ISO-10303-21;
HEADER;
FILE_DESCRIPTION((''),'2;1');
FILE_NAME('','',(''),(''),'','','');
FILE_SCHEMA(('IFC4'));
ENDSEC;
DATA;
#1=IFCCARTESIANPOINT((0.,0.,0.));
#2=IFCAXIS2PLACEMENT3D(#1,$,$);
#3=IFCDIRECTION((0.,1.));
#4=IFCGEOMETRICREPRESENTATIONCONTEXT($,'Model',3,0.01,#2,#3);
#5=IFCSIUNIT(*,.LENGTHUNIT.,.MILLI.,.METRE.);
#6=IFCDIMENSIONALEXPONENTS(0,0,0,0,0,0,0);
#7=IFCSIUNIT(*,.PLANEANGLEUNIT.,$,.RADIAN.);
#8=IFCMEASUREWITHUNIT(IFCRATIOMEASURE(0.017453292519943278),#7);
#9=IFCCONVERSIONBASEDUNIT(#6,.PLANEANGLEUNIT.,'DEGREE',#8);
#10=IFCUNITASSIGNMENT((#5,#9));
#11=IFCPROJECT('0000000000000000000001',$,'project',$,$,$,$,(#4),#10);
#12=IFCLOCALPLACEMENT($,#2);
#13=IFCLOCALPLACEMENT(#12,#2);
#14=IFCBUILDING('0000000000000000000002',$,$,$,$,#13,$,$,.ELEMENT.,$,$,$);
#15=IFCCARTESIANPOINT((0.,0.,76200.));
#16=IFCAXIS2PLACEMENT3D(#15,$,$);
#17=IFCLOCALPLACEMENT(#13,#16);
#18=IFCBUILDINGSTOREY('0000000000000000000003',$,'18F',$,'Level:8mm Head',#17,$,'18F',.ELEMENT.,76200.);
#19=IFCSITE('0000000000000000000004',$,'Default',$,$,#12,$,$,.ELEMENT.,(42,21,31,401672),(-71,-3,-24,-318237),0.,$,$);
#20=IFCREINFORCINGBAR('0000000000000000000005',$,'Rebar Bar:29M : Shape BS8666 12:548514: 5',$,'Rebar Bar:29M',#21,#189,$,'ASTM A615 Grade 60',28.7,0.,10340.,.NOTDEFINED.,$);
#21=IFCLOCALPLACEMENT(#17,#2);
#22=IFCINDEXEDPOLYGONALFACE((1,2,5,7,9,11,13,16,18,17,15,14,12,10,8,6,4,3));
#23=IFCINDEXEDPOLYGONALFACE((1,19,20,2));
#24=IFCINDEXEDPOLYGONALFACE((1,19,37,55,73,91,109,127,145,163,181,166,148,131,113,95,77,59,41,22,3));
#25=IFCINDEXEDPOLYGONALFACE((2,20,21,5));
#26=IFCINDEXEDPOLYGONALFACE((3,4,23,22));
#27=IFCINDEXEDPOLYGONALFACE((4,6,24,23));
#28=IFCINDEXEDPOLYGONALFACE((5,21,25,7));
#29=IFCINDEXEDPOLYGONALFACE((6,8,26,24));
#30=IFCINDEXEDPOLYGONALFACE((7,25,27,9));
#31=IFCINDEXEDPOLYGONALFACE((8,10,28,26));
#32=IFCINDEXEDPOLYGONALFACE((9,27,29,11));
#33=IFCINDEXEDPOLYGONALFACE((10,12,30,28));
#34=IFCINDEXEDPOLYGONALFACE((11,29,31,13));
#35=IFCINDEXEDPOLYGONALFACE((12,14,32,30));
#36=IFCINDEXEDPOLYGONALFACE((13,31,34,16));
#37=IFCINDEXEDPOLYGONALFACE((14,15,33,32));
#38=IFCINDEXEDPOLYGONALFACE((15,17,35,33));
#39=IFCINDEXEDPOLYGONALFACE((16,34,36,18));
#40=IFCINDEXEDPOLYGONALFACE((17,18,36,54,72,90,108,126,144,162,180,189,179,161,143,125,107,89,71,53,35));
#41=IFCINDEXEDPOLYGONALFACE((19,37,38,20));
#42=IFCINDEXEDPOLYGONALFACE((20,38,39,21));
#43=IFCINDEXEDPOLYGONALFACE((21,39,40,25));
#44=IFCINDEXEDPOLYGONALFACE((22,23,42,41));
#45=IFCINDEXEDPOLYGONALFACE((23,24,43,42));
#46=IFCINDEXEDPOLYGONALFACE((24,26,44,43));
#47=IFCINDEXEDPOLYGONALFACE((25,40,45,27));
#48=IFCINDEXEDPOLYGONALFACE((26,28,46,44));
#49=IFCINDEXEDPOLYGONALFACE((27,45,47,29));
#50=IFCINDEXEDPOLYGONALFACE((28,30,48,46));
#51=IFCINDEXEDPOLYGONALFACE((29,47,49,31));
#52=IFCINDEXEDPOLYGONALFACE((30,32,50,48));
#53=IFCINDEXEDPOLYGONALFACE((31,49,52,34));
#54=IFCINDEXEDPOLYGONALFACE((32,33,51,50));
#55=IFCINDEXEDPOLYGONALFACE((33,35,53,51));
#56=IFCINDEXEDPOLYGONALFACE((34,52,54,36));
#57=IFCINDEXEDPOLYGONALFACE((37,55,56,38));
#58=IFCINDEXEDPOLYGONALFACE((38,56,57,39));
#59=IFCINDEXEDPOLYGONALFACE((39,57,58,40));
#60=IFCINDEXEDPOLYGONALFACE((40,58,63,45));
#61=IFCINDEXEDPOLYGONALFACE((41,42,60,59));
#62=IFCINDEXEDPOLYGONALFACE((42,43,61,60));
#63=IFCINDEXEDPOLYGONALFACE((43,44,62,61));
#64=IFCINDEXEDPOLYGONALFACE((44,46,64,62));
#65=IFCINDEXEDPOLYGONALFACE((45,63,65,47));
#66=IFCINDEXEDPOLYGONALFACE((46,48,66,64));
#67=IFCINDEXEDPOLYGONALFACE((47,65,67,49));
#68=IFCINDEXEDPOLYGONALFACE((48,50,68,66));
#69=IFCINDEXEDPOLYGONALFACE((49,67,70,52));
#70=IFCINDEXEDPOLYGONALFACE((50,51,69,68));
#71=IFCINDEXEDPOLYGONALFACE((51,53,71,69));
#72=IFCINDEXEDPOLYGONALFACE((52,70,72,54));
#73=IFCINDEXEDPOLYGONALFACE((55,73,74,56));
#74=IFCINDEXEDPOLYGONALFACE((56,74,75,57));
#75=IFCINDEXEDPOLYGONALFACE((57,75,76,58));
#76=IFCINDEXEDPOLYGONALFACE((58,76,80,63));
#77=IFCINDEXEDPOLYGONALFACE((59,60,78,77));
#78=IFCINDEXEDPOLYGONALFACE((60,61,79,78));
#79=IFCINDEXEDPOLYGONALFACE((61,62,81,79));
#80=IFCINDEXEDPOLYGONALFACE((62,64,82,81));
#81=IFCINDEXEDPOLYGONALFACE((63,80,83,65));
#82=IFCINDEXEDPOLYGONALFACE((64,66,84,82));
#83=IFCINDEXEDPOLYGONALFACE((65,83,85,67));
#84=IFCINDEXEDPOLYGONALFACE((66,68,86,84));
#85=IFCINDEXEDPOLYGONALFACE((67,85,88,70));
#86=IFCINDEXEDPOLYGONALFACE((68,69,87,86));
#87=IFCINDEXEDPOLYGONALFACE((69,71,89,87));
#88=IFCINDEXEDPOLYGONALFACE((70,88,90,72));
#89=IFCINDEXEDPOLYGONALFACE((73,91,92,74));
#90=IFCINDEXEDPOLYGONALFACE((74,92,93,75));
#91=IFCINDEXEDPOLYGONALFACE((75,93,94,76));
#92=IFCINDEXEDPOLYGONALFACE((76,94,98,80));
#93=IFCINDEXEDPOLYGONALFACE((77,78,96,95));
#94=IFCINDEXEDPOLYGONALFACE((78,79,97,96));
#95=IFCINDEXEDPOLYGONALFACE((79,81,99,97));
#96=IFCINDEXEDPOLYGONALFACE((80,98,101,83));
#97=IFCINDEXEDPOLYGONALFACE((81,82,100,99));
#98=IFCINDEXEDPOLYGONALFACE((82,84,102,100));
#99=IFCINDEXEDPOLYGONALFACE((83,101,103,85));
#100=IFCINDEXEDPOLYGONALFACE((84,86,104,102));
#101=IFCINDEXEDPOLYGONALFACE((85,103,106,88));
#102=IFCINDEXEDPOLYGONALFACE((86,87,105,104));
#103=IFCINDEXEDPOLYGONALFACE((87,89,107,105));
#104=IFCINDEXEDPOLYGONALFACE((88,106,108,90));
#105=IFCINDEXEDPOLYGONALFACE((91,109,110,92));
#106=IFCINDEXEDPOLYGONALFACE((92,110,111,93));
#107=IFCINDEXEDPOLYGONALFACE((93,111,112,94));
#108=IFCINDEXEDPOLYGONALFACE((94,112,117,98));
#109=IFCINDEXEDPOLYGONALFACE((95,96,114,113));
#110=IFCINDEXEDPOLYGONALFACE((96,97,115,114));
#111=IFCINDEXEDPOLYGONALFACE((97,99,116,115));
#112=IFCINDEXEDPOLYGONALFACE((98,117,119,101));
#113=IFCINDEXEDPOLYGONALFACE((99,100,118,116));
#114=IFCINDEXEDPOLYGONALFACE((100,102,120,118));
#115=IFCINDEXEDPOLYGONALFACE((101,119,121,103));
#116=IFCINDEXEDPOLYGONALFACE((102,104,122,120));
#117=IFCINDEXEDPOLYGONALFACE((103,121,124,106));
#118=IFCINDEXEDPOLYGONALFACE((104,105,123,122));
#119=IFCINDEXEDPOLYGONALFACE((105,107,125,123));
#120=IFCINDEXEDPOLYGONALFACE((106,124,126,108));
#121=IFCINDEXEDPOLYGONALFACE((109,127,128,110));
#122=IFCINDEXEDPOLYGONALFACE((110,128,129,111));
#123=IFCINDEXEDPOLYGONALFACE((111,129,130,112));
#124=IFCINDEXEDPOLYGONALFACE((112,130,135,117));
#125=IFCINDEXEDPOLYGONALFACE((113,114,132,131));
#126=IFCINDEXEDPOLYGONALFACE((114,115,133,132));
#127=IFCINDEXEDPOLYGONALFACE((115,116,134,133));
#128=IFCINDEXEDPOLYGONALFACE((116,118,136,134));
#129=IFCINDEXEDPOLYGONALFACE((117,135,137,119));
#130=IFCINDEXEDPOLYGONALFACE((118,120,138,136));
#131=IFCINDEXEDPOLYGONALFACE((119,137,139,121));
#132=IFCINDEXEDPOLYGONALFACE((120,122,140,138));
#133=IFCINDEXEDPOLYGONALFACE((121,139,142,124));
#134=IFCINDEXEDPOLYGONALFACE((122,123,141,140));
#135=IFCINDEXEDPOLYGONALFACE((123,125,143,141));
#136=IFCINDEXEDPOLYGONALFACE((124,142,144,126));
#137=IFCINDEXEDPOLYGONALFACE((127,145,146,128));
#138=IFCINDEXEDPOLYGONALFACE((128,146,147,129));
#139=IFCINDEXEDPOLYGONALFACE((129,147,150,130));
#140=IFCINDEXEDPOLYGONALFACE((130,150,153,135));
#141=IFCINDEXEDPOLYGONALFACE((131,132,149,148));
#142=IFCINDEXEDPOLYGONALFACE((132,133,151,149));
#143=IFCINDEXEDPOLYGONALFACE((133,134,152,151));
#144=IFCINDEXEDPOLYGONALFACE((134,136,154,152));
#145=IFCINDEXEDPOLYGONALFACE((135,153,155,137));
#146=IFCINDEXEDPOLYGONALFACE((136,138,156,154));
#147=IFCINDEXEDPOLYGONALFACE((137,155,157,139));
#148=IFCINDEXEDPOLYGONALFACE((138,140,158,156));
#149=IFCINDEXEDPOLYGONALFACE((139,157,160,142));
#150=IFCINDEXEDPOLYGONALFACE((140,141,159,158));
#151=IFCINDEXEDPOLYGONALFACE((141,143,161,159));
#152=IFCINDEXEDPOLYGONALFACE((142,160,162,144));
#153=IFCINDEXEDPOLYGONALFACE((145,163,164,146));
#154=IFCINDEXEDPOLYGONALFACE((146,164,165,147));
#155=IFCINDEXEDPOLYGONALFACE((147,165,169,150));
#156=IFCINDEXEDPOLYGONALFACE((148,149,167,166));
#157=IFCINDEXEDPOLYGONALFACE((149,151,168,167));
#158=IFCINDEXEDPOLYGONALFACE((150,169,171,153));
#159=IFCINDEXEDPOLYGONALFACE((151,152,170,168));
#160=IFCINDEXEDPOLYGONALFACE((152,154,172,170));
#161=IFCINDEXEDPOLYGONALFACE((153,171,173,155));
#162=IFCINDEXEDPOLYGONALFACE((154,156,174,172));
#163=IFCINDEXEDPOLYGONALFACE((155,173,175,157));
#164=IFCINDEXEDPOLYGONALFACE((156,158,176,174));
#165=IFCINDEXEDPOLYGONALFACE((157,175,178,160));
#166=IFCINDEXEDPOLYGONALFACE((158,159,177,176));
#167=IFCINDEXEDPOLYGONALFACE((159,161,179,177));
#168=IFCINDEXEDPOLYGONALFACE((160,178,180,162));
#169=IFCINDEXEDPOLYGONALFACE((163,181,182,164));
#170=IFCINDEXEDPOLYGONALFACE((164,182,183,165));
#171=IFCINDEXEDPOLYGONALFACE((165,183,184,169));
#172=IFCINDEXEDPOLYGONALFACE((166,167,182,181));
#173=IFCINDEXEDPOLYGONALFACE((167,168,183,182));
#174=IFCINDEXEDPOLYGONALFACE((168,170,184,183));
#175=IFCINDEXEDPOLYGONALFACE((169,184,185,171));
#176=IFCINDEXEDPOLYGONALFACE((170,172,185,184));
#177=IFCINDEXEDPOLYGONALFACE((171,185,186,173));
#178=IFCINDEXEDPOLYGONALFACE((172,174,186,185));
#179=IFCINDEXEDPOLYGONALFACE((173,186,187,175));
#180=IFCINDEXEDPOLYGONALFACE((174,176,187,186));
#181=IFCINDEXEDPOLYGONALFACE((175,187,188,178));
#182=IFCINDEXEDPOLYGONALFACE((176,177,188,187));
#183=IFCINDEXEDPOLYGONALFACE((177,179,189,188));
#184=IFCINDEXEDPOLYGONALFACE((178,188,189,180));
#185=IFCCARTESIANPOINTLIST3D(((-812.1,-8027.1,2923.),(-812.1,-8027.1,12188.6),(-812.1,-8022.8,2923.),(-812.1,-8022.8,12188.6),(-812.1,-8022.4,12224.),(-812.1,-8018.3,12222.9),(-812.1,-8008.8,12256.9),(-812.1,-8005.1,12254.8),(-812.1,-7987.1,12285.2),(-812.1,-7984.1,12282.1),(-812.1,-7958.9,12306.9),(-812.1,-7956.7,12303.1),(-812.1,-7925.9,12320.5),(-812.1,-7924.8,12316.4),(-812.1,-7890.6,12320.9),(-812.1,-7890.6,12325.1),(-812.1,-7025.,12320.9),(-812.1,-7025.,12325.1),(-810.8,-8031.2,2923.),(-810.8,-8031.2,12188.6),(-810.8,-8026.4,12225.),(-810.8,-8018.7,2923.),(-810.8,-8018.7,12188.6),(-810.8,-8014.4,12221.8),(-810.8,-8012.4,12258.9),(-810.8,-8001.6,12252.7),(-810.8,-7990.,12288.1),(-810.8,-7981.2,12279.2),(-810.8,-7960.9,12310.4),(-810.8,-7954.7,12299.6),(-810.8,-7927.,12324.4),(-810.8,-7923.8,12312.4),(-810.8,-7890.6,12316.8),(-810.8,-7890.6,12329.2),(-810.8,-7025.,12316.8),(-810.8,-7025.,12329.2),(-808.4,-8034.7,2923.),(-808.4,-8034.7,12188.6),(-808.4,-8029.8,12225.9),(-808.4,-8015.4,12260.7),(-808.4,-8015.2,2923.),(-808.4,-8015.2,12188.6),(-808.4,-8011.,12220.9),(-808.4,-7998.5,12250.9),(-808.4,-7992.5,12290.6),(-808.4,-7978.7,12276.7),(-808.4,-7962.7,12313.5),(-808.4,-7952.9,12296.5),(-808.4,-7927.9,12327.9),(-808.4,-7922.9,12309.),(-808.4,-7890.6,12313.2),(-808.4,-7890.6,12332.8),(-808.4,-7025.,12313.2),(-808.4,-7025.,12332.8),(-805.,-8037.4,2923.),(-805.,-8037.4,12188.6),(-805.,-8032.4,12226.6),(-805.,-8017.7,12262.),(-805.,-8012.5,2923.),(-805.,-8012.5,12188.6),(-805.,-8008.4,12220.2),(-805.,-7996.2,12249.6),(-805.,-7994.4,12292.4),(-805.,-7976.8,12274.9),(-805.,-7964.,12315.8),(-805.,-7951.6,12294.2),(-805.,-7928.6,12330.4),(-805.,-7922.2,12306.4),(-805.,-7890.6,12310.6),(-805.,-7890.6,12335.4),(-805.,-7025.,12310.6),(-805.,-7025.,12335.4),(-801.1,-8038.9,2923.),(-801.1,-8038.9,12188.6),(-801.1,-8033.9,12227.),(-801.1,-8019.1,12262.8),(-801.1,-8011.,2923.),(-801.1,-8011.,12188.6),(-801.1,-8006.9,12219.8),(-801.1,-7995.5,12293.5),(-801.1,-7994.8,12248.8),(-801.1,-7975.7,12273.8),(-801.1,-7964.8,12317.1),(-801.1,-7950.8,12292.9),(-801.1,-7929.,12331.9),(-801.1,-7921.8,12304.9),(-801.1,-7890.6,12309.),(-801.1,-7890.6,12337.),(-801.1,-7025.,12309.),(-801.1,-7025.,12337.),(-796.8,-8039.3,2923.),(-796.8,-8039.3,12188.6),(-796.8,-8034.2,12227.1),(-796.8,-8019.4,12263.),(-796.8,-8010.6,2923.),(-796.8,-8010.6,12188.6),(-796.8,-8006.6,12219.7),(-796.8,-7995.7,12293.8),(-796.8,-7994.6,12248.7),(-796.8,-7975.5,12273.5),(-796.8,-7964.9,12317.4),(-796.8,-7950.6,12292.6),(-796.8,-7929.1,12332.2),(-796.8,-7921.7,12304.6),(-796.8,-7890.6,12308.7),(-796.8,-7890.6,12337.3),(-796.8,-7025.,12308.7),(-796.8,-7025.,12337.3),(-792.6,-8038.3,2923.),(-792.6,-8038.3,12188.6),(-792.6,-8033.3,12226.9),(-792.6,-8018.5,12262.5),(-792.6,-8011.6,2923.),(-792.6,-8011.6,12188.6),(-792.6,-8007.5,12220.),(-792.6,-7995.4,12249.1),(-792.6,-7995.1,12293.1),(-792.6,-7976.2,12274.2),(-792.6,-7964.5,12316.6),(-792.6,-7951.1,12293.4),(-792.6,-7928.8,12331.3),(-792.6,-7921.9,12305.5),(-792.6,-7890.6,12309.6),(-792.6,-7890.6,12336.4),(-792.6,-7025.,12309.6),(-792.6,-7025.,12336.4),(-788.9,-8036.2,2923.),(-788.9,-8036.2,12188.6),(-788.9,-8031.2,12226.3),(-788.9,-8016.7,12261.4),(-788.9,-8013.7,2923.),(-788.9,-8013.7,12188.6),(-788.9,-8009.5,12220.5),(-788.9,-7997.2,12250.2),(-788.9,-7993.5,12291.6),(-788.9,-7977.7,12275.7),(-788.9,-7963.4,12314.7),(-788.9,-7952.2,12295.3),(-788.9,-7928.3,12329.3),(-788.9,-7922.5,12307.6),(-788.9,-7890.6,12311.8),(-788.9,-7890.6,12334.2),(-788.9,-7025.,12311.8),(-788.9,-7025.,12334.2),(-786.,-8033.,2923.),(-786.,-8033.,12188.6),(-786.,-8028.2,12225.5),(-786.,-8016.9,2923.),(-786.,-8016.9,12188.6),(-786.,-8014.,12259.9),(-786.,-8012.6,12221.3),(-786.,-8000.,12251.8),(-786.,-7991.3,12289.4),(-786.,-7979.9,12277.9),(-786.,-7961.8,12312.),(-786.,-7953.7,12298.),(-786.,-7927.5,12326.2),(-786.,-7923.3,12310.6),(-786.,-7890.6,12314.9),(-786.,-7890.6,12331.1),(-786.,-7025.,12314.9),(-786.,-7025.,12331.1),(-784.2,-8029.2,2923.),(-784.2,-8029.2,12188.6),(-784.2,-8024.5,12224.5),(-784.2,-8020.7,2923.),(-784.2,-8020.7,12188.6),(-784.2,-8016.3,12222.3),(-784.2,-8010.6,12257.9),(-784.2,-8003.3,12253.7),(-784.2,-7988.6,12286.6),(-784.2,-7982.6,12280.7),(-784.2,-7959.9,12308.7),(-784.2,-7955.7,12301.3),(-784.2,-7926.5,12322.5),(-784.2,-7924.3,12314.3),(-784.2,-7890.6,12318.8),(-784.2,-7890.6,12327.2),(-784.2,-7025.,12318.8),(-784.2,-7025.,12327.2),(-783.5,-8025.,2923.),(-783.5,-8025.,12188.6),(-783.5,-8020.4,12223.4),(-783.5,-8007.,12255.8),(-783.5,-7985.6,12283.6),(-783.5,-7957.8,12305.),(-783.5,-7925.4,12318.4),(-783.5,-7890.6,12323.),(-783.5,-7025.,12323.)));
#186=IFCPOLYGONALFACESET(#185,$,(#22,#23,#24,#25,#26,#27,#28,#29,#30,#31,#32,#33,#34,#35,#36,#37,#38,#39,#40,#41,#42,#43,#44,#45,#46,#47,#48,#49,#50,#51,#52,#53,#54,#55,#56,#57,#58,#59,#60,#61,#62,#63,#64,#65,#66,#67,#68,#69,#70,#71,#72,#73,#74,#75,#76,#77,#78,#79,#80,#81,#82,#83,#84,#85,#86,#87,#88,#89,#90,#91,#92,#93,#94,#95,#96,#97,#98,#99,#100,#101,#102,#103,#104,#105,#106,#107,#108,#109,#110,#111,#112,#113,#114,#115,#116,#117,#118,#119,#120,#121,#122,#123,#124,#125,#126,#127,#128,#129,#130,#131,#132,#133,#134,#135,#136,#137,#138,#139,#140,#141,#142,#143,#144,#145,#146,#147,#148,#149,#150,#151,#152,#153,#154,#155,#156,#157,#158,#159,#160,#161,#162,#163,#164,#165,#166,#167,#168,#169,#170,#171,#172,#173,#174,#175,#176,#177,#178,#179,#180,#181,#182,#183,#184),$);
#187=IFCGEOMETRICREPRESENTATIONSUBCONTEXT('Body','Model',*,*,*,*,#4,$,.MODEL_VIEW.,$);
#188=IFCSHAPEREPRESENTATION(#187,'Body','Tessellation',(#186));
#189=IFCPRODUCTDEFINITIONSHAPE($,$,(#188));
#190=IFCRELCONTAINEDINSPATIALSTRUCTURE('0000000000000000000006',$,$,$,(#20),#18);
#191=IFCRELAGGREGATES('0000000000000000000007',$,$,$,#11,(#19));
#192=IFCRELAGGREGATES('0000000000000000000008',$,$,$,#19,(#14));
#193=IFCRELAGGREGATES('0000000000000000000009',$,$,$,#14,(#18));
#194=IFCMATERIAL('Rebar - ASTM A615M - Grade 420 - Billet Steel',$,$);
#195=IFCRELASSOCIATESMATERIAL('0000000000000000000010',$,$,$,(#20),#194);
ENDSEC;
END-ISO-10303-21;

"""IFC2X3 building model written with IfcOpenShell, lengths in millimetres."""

from ifc_helpers import new_model, entity, si_unit, converted_unit, direction, frame, origin, place, context, subcontext, project, spatial, material, element, save


model = new_model("IFC2X3")

# Units and contexts
model_context = context("Model", 3, precision=0.01, world=origin(), true_north=direction((0.0, 1.0)))
body_context = subcontext(model_context, "Body", "Model", "MODEL_VIEW")
ifc_project = project(units=[si_unit("LENGTHUNIT", "METRE", prefix="MILLI"), converted_unit("PLANEANGLEUNIT", "DEGREE", entity("IfcRatioMeasure", 0.017453292519943278), si_unit("PLANEANGLEUNIT", "RADIAN"), dimensions=[0, 0, 0, 0, 0, 0, 0])], contexts=[model_context])

# Site, building, storey
site_placement = place(None, origin())
site = spatial("IfcSite", under=ifc_project, at=site_placement, Name="Default", CompositionType="ELEMENT", RefLatitude=(42, 21, 31, 401672), RefLongitude=(-71, -3, -24, -318237), RefElevation=0.0)
building_placement = place(site_placement, origin())
building = spatial("IfcBuilding", under=site, at=building_placement, CompositionType="ELEMENT")
storey_placement = place(building_placement, frame((0.0, 0.0, 76200.0)))
storey = spatial("IfcBuildingStorey", under=building, at=storey_placement, Name="18F", ObjectType="Level:8mm Head", LongName="18F", CompositionType="ELEMENT", Elevation=76200.0)

# Reinforcing bar
ifc_material_1 = material(Name="Rebar - ASTM A615M - Grade 420 - Billet Steel")
reinforcing_bar_1_placement = place(storey_placement, origin())
element("IfcReinforcingBar", 1, at=reinforcing_bar_1_placement, inside=storey, material=ifc_material_1, Name="Rebar Bar:29M : Shape BS8666 12:548514: 5", SteelGrade="ASTM A615 Grade 60", ObjectType="Rebar Bar:29M", BarLength=10340.0, BarRole="NOTDEFINED", CrossSectionArea=0.0, NominalDiameter=28.7, context=body_context, shape_type="AdvancedSweptSolid", body=[
    entity("IfcSweptDiskSolid", entity("IfcCompositeCurve", [entity("IfcCompositeCurveSegment", "CONTINUOUS", True, entity("IfcPolyline", [entity("IfcCartesianPoint", [-797.9, -8025.0, 2923.0]), entity("IfcCartesianPoint", [-797.9, -8025.0, 12188.6])])), entity("IfcCompositeCurveSegment", "CONTINUOUS", True, entity("IfcTrimmedCurve", entity("IfcCircle", entity("IfcAxis2Placement3D", entity("IfcCartesianPoint", [-797.9, -7890.6, 12188.6]), entity("IfcDirection", [-1.0, 0.0, 0.0]), entity("IfcDirection", [0.0, 0.0, 1.0])), 134.3), [entity("IfcParameterValue", 270.0)], [entity("IfcParameterValue", 360.0)], True, "PARAMETER")), entity("IfcCompositeCurveSegment", "CONTINUOUS", True, entity("IfcPolyline", [entity("IfcCartesianPoint", [-797.9, -7890.6, 12323.0]), entity("IfcCartesianPoint", [-797.9, -7025.0, 12323.0])]))], False), 14.3, None, 0.0, 92.0),
])

save(model, "model.ifc")
